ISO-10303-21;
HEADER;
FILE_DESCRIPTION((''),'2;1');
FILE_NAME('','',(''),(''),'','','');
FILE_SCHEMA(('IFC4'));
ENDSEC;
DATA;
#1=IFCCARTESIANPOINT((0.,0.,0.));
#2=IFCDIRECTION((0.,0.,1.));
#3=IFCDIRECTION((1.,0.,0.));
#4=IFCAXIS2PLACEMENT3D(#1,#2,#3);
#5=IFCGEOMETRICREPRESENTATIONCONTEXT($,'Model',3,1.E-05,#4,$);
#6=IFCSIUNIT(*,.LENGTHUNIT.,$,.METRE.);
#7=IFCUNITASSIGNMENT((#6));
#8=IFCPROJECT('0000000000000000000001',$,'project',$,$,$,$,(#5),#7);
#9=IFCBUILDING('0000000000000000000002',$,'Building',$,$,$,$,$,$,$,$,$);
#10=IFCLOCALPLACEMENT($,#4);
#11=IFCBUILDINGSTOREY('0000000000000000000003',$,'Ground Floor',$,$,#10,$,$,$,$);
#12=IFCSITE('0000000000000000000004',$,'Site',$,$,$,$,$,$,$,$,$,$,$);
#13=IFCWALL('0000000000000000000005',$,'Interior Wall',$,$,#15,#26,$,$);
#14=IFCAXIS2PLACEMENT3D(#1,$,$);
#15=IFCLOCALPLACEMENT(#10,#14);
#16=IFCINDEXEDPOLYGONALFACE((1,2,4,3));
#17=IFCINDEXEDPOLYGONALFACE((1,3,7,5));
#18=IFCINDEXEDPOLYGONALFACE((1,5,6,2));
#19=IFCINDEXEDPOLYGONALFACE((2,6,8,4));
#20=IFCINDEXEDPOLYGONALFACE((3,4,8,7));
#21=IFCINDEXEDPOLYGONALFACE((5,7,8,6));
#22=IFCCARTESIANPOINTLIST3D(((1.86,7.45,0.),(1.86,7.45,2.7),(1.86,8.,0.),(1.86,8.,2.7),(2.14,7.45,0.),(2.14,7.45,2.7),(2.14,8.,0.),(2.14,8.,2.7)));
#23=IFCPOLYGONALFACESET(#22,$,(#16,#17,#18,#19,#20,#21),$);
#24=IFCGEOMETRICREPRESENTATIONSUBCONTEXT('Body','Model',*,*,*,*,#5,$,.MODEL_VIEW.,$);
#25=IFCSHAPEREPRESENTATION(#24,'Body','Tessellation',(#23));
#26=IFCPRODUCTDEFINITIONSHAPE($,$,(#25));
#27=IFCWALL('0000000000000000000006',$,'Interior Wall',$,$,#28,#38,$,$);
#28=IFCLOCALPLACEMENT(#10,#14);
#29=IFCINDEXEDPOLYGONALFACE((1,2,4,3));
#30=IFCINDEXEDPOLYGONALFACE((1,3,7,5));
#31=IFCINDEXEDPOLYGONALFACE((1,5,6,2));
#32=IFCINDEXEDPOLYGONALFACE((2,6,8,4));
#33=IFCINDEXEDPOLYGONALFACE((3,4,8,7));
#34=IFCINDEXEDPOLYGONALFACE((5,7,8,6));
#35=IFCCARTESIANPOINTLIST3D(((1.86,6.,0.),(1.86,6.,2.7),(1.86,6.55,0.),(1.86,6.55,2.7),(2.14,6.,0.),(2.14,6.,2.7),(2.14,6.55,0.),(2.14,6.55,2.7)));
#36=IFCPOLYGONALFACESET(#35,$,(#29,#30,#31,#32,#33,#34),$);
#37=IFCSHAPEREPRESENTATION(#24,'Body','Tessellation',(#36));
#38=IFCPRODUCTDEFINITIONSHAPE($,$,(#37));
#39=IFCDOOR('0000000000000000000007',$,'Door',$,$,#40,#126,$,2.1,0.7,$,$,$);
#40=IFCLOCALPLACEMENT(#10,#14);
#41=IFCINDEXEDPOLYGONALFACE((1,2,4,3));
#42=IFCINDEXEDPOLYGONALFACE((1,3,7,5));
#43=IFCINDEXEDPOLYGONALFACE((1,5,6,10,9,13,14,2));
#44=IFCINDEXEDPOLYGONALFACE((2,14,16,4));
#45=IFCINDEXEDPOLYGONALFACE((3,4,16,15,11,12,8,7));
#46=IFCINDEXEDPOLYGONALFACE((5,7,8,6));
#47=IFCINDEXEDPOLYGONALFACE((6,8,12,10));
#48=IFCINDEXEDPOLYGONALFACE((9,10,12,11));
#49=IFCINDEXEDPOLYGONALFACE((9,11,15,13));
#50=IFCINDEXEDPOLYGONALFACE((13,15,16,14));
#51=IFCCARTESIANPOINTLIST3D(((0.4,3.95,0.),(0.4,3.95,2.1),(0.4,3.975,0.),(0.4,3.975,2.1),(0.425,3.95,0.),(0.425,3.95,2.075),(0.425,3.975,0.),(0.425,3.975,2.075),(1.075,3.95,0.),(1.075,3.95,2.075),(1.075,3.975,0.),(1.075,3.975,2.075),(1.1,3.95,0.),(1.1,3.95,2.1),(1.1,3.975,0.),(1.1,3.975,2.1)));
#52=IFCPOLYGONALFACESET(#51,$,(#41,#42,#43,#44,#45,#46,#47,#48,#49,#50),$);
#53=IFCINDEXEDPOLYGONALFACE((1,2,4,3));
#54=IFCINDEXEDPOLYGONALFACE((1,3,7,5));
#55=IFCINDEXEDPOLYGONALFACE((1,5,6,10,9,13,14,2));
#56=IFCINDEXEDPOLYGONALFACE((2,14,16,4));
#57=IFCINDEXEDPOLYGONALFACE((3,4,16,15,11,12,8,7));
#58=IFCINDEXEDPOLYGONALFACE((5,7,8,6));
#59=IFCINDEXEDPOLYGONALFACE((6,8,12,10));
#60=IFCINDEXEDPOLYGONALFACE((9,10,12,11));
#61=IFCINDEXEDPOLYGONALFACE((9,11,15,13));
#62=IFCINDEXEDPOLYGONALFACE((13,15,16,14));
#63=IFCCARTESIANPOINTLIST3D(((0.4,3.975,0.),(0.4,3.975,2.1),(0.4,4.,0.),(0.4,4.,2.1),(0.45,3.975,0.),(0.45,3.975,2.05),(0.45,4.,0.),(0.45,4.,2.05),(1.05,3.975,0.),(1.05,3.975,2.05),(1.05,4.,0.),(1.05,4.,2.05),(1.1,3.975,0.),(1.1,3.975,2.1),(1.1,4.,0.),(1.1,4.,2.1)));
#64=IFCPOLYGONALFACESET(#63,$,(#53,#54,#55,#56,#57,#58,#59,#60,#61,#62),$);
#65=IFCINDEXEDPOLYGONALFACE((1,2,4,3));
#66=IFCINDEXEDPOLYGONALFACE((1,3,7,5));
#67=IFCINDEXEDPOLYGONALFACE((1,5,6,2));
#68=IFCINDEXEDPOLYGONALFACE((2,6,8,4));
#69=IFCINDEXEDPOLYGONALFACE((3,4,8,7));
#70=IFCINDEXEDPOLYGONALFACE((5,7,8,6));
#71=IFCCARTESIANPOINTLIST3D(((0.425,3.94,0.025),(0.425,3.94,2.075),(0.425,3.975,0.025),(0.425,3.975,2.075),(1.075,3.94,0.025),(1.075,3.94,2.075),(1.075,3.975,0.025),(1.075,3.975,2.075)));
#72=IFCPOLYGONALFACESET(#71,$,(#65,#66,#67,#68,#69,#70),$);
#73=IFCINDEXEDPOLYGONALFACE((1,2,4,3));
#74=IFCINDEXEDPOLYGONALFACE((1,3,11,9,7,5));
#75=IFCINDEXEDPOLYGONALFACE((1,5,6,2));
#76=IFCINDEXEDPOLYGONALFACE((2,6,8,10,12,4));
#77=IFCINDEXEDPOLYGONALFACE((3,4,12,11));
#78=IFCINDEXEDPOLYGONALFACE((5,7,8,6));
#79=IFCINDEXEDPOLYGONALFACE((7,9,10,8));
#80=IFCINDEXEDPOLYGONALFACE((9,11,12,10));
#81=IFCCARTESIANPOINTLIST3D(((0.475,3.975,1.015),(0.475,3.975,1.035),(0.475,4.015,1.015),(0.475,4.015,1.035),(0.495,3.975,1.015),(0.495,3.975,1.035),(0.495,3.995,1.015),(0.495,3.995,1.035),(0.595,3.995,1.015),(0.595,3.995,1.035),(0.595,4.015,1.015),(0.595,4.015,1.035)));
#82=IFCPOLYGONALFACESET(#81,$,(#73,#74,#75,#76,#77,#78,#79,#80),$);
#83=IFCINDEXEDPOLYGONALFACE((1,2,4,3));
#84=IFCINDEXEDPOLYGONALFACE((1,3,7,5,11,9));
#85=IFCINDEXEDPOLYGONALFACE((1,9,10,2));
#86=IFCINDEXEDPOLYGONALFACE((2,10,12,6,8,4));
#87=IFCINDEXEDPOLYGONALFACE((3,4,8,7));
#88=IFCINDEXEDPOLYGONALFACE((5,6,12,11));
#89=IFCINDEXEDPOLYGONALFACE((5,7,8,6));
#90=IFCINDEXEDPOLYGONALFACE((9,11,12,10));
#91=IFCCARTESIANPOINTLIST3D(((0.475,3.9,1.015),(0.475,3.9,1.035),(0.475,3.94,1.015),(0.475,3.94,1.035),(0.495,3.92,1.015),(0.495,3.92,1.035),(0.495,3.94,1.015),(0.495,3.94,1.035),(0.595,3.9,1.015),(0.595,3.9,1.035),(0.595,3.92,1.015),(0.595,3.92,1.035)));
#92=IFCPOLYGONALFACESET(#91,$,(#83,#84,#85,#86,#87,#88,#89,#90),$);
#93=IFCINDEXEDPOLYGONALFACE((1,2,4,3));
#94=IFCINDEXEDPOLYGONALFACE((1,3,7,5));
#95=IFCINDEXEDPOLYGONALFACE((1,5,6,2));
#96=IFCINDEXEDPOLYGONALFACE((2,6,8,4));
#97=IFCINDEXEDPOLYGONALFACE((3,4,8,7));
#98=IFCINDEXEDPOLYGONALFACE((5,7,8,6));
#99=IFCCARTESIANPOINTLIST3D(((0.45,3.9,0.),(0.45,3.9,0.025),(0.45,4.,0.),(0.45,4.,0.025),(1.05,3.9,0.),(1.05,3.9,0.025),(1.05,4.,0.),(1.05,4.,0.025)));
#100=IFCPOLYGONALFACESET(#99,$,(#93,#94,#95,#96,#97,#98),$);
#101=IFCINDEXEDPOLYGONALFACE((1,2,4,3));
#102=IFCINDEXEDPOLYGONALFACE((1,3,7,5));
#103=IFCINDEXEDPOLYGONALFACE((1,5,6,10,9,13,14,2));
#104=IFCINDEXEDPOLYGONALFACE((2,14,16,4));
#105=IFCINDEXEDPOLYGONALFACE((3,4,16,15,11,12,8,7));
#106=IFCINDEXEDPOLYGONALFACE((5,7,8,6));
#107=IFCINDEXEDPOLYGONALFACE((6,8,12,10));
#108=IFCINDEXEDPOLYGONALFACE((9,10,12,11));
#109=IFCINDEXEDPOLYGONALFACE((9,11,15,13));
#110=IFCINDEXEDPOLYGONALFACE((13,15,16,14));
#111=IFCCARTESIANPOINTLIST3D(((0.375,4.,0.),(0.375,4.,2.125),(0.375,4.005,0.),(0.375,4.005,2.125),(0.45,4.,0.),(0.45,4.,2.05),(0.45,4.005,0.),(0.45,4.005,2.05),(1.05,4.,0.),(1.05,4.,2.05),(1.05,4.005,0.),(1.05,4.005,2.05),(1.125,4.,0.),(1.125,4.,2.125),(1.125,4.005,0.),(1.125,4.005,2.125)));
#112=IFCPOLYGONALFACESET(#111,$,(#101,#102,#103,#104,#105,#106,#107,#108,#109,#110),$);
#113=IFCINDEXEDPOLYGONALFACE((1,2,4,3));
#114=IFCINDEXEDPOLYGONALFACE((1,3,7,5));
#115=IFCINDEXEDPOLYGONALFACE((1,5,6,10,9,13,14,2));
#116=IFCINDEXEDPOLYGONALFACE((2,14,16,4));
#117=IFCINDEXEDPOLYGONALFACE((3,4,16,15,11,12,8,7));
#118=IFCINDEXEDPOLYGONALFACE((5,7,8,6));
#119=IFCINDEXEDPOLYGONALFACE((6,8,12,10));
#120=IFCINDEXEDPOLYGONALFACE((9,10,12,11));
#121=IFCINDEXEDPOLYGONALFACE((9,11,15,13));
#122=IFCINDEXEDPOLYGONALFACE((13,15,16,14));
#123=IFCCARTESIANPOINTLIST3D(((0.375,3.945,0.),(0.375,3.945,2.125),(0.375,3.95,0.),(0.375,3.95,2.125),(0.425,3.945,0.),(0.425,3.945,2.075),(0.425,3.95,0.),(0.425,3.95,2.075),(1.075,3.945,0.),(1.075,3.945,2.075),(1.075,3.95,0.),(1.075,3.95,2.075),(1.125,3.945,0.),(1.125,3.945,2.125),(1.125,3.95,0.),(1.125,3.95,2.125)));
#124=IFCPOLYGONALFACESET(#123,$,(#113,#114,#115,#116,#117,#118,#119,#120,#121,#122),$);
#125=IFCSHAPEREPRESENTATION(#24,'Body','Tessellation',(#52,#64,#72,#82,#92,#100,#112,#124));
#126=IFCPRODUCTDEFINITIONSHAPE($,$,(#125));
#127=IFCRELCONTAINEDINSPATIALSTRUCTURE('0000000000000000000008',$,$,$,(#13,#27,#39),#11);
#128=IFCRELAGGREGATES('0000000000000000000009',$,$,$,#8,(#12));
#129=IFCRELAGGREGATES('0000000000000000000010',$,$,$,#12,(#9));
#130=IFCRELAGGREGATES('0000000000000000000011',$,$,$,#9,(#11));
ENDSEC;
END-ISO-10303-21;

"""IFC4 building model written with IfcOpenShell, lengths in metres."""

from ifc_helpers import new_model, si_unit, frame, origin_with_axes, place, context, subcontext, project, spatial, line, indexed_curve, outline, extrude, element, save


model = new_model("IFC4")

# Units and contexts
model_context = context("Model", 3, precision=1e-05, world=origin_with_axes())
body_context = subcontext(model_context, "Body", "Model", "MODEL_VIEW")
ifc_project = project(units=[si_unit("LENGTHUNIT", "METRE")], contexts=[model_context])

# Site, building, storey
site = spatial("IfcSite", under=ifc_project, Name="Site")
building = spatial("IfcBuilding", under=site, Name="Building")
storey_placement = place(None, origin_with_axes())
storey = spatial("IfcBuildingStorey", under=building, at=storey_placement, Name="Ground Floor")

# Walls
for number, where, z_axis, x_axis, name in (
    (1, (2.0, 8.0, 0.0), (0.0, 0.0, 1.0), (0.0, -1.0, 0.0), "Interior Wall"),
    (2, (2.0, 6.55, 0.0), (0.0, 0.0, 1.0), (0.0, -1.0, 0.0), "Interior Wall"),
):
    element("IfcWall", number, at=place(storey_placement, frame(where, z_axis=z_axis, x_axis=x_axis)), inside=storey, Name=name, context=body_context, shape_type="SweptSolid", body=[
        extrude(outline(indexed_curve([(0.0, 0.0), (0.0, 0.28), (0.55, 0.28), (0.55, 0.0), (0.0, 0.0)], self_intersect=False)), frame((0.0, -0.14, 0.0), z_axis=(0.0, 0.0, 1.0), x_axis=(1.0, 0.0, 0.0)), (0.0, 0.0, 1.0), 2.7),
    ])

# Door
door_1_placement = place(storey_placement, frame((1.1, 4.0, 0.0), z_axis=(0.0, 0.0, 1.0), x_axis=(-1.0, 0.0, 0.0)))
element("IfcDoor", 3, at=door_1_placement, inside=storey, Name="Door", OverallHeight=2.1, OverallWidth=0.7, context=body_context, shape_type="SweptSolid", body=[
    extrude(outline(indexed_curve([(0.0, 0.0), (0.0, 2.1), (0.7, 2.1), (0.7, 0.0), (0.675, 0.0), (0.675, 2.075), (0.025, 2.075), (0.025, 0.0)], segments=[line(1, 2, 3, 4, 5, 6, 7, 8, 1)])), frame((0.0, 0.025, 0.0), z_axis=(0.0, -1.0, 0.0), x_axis=(1.0, 0.0, 0.0)), (0.0, 0.0, -1.0), 0.025),
    extrude(outline(indexed_curve([(0.0, 0.0), (0.0, 2.1), (0.7, 2.1), (0.7, 0.0), (0.65, 0.0), (0.65, 2.05), (0.05, 2.05), (0.05, 0.0)], segments=[line(1, 2, 3, 4, 5, 6, 7, 8, 1)])), frame((0.0, 0.0, 0.0), z_axis=(0.0, -1.0, 0.0), x_axis=(1.0, 0.0, 0.0)), (0.0, 0.0, -1.0), 0.025),
    extrude(outline(indexed_curve([(0.0, 0.0), (0.65, 0.0), (0.65, 0.035), (0.0, 0.035)], segments=[line(1, 2, 3, 4, 1)])), frame((0.025, 0.025, 0.025), z_axis=(0.0, 0.0, 1.0), x_axis=(1.0, 0.0, 0.0)), (0.0, 0.0, 1.0), 2.05),
    extrude(outline(indexed_curve([(0.0, 0.0), (0.0, -0.04), (-0.12, -0.04), (-0.12, -0.02), (-0.02, -0.02), (-0.02, 0.0)], segments=[line(1, 2, 3, 4, 5, 6, 1)])), frame((0.625, 0.025, 1.015), z_axis=(0.0, 0.0, 1.0), x_axis=(1.0, 0.0, 0.0)), (0.0, 0.0, 1.0), 0.02),
    extrude(outline(indexed_curve([(0.0, 0.0), (0.0, 0.04), (-0.12, 0.04), (-0.12, 0.02), (-0.02, 0.02), (-0.02, 0.0)], segments=[line(1, 2, 3, 4, 5, 6, 1)])), frame((0.625, 0.06, 1.015), z_axis=(0.0, 0.0, 1.0), x_axis=(1.0, 0.0, 0.0)), (0.0, 0.0, 1.0), 0.02),
    extrude(outline(indexed_curve([(0.0, 0.0), (0.6, 0.0), (0.6, 0.1), (0.0, 0.1)], segments=[line(1, 2, 3, 4, 1)])), frame((0.05, 0.0, 0.0), z_axis=(0.0, 0.0, 1.0), x_axis=(1.0, 0.0, 0.0)), (0.0, 0.0, 1.0), 0.025),
    extrude(outline(indexed_curve([(0.0, 0.0), (0.0, 2.125), (0.75, 2.125), (0.75, 0.0), (0.675, 0.0), (0.675, 2.05), (0.075, 2.05), (0.075, 0.0)], segments=[line(1, 2, 3, 4, 5, 6, 7, 8, 1)])), frame((-0.025, -0.005, 0.0), z_axis=(0.0, -1.0, 0.0), x_axis=(1.0, 0.0, 0.0)), (0.0, 0.0, -1.0), 0.005),
    extrude(outline(indexed_curve([(0.0, 0.0), (0.0, 2.125), (0.75, 2.125), (0.75, 0.0), (0.7, 0.0), (0.7, 2.075), (0.05, 2.075), (0.05, 0.0)], segments=[line(1, 2, 3, 4, 5, 6, 7, 8, 1)])), frame((-0.025, 0.05, 0.0), z_axis=(0.0, -1.0, 0.0), x_axis=(1.0, 0.0, 0.0)), (0.0, 0.0, -1.0), 0.005),
])

save(model, "model.ifc")
